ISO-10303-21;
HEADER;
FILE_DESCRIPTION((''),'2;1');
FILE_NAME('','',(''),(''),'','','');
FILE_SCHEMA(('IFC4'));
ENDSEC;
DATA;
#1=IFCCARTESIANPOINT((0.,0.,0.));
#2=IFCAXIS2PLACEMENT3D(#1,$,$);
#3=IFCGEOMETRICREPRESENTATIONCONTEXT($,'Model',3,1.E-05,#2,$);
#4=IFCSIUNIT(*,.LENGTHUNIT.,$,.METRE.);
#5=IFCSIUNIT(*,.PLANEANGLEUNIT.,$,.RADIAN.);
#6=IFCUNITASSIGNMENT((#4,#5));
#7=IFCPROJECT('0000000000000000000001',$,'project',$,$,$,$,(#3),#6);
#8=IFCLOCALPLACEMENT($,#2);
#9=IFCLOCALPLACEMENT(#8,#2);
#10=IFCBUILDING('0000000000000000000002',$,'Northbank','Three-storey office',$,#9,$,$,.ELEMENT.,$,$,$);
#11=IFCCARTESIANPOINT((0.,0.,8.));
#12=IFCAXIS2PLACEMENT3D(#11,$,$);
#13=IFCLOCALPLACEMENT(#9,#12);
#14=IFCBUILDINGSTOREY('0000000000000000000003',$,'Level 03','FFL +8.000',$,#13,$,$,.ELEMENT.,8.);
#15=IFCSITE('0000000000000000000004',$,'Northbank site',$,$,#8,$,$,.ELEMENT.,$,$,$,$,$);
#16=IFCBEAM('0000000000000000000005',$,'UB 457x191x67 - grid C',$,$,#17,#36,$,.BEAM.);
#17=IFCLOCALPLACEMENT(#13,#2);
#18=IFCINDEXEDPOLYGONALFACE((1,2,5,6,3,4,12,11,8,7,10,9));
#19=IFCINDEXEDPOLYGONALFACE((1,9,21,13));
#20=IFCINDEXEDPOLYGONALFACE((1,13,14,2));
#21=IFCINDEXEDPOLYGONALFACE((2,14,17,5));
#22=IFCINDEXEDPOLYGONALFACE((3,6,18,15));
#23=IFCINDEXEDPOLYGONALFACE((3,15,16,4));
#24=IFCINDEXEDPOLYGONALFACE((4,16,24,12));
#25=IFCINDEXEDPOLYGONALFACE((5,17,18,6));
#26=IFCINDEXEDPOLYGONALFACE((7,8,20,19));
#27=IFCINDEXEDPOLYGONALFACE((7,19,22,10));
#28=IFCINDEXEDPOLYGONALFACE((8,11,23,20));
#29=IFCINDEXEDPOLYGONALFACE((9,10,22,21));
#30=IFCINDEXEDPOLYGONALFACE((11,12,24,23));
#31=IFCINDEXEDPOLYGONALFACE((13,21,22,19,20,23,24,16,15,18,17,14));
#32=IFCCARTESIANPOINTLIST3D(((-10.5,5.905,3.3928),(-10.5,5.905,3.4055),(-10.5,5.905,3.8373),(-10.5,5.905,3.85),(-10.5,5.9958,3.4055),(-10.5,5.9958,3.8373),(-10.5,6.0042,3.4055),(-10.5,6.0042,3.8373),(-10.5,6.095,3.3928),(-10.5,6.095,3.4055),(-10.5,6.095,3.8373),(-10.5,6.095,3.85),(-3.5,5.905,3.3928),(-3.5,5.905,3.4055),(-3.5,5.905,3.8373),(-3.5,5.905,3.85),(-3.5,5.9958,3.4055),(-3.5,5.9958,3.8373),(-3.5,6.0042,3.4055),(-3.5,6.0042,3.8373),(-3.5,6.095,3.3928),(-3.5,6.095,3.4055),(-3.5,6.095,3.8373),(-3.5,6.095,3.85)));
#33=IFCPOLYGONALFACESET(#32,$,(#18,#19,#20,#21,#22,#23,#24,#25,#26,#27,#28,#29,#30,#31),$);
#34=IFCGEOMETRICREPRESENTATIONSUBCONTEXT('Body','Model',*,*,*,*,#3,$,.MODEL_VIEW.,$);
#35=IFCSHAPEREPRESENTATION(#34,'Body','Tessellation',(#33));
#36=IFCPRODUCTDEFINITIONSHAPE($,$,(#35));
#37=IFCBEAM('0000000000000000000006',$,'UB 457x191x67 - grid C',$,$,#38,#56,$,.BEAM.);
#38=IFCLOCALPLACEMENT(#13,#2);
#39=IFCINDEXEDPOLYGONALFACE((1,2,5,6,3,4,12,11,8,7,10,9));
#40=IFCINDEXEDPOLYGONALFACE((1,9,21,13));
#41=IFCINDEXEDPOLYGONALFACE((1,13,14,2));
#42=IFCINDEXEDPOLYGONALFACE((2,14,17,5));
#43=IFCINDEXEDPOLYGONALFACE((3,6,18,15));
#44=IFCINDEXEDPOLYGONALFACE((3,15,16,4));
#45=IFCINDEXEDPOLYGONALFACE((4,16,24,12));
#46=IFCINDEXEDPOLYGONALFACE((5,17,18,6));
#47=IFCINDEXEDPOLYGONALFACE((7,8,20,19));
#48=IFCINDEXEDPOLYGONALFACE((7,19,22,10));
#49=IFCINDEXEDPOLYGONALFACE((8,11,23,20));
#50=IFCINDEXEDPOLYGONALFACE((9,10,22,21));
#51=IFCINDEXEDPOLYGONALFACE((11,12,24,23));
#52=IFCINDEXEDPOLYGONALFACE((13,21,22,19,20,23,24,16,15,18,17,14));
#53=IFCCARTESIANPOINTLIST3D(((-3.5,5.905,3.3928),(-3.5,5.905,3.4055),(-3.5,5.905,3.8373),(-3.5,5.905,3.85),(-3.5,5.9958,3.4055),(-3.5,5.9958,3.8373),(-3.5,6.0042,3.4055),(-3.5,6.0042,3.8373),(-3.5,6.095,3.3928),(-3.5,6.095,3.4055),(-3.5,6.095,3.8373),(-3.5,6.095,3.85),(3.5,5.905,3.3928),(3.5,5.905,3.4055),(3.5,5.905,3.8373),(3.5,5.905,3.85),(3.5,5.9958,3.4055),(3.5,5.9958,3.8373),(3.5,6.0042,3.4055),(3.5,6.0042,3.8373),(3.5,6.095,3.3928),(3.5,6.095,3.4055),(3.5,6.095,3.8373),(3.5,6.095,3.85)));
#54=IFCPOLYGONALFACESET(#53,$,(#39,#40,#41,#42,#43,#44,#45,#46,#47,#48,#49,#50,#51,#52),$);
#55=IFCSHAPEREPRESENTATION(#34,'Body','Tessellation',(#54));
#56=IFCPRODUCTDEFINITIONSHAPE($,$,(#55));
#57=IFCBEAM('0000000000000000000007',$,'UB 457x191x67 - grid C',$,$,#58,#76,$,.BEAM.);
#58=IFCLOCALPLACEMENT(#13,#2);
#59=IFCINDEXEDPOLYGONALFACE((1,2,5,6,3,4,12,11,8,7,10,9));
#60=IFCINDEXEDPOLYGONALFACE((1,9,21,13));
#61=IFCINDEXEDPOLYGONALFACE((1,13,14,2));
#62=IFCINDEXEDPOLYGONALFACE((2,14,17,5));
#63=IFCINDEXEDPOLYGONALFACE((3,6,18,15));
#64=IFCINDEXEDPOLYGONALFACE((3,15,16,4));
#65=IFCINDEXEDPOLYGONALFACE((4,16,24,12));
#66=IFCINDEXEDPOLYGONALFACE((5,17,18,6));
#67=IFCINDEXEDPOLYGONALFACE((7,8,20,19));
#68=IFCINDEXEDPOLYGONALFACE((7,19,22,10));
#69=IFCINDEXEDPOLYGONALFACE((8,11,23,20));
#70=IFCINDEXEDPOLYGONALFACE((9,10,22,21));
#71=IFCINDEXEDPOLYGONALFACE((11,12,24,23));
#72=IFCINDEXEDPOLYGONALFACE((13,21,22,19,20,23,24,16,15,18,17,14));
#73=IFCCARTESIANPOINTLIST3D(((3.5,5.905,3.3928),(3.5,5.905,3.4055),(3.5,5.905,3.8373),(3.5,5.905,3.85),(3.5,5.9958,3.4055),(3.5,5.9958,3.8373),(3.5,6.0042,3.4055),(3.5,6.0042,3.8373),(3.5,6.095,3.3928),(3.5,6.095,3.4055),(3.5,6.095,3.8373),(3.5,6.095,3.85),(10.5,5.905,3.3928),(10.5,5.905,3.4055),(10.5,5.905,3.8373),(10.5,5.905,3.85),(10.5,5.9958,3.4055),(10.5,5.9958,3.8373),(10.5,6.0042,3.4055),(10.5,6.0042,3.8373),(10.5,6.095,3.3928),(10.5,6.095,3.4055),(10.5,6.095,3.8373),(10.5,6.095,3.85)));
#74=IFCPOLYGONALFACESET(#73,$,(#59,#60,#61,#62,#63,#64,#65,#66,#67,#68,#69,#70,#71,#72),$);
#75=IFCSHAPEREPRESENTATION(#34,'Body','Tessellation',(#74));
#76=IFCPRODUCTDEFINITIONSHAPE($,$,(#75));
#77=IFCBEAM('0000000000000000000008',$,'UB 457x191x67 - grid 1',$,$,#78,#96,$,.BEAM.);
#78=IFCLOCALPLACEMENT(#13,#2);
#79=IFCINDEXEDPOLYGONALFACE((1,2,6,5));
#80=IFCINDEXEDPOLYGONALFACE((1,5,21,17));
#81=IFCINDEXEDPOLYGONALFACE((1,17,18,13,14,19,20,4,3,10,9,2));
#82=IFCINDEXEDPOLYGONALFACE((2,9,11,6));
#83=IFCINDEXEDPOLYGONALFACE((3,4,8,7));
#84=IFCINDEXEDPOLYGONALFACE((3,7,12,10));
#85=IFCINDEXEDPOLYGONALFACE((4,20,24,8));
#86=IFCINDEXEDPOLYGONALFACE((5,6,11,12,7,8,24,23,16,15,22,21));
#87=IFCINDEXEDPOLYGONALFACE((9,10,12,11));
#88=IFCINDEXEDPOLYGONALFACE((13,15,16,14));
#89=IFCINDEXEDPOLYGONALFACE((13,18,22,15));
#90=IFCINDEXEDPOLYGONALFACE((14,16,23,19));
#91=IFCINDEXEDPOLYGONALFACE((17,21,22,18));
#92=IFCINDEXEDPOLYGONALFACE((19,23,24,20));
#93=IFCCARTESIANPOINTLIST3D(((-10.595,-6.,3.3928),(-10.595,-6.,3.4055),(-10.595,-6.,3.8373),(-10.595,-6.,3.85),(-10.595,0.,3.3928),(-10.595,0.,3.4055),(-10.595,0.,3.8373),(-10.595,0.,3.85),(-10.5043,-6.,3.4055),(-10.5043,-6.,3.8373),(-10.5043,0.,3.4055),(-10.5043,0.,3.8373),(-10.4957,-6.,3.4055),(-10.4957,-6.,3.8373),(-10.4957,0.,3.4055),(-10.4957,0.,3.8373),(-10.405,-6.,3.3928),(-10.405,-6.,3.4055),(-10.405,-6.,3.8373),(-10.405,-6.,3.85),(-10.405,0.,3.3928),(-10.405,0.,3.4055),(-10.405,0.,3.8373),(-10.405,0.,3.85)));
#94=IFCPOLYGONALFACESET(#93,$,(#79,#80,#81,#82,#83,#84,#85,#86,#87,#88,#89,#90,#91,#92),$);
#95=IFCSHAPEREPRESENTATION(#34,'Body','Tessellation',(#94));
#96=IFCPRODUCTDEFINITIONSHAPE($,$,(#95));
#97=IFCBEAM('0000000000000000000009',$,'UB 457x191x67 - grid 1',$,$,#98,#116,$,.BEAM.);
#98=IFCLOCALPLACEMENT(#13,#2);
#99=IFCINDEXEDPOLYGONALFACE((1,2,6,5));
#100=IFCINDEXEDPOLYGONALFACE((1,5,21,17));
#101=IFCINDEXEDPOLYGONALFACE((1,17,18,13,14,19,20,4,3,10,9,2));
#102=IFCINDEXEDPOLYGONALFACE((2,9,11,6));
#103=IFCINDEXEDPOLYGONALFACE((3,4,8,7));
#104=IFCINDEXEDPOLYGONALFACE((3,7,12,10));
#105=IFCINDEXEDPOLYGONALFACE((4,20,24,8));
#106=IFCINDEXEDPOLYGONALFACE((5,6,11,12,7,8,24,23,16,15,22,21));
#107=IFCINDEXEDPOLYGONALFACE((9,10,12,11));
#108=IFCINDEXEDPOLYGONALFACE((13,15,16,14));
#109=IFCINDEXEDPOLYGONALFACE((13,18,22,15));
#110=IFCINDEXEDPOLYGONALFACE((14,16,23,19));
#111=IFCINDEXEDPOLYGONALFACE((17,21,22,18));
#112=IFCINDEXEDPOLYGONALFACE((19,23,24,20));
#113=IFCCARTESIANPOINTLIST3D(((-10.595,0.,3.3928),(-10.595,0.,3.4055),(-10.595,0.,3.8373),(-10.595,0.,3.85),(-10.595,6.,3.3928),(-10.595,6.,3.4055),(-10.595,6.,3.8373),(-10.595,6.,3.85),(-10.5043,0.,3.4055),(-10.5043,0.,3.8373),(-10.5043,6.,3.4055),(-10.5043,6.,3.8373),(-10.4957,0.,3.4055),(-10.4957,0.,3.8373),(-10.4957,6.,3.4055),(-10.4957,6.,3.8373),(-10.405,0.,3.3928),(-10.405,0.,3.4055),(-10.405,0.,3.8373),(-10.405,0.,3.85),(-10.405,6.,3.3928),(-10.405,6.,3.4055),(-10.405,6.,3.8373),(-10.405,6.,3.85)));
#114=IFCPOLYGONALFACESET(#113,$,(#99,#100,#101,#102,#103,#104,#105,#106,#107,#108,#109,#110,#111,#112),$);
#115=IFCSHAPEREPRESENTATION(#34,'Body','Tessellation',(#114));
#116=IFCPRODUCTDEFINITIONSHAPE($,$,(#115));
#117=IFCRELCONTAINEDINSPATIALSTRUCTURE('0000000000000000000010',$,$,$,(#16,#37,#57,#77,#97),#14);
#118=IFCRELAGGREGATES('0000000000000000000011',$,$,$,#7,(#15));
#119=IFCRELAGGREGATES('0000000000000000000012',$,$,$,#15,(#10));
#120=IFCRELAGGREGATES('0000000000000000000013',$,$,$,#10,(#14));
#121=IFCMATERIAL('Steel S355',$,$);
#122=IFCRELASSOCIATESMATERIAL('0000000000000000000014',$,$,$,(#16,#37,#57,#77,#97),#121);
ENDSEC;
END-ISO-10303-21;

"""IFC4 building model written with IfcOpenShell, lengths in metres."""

from ifc_helpers import new_model, si_unit, frame, origin, place, context, subcontext, project, spatial, i_section, extrude, material, element, save


model = new_model("IFC4")

# Units and contexts
model_context = context("Model", 3, precision=1e-05, world=origin())
body_context = subcontext(model_context, "Body", "Model", "MODEL_VIEW")
ifc_project = project(units=[si_unit("LENGTHUNIT", "METRE"), si_unit("PLANEANGLEUNIT", "RADIAN")], contexts=[model_context])

# Site, building, storey
site_placement = place(None, origin())
site = spatial("IfcSite", under=ifc_project, at=site_placement, Name="Northbank site", CompositionType="ELEMENT")
building_placement = place(site_placement, origin())
building = spatial("IfcBuilding", under=site, at=building_placement, Name="Northbank", Description="Three-storey office", CompositionType="ELEMENT")
storey_placement = place(building_placement, frame((0.0, 0.0, 8.0)))
storey = spatial("IfcBuildingStorey", under=building, at=storey_placement, Name="Level 03", Description="FFL +8.000", CompositionType="ELEMENT", Elevation=8.0)

# Shared definitions
ifc_material = material(Name="Steel S355")

# Beams
beam_1_placement = place(storey_placement, frame((0.0, 0.0, -8.0)))
element("IfcBeam", 1, at=beam_1_placement, inside=storey, material=ifc_material, Name="UB 457x191x67 - grid C", PredefinedType="BEAM", context=body_context, shape_type="SweptSolid", body=[
    extrude(i_section(OverallWidth=0.1899, OverallDepth=0.4572, WebThickness=0.0085, FlangeThickness=0.0127), frame((-10.5, 6.0, 11.6214), z_axis=(1.0, 0.0, 0.0), x_axis=(0.0, 1.0, 0.0)), (0.0, 0.0, 1.0), 7.0),
])
beam_2_placement = place(storey_placement, frame((0.0, 0.0, -8.0)))
element("IfcBeam", 2, at=beam_2_placement, inside=storey, material=ifc_material, Name="UB 457x191x67 - grid C", PredefinedType="BEAM", context=body_context, shape_type="SweptSolid", body=[
    extrude(i_section(OverallWidth=0.1899, OverallDepth=0.4572, WebThickness=0.0085, FlangeThickness=0.0127), frame((-3.5, 6.0, 11.6214), z_axis=(1.0, 0.0, 0.0), x_axis=(0.0, 1.0, 0.0)), (0.0, 0.0, 1.0), 7.0),
])
beam_3_placement = place(storey_placement, frame((0.0, 0.0, -8.0)))
element("IfcBeam", 3, at=beam_3_placement, inside=storey, material=ifc_material, Name="UB 457x191x67 - grid C", PredefinedType="BEAM", context=body_context, shape_type="SweptSolid", body=[
    extrude(i_section(OverallWidth=0.1899, OverallDepth=0.4572, WebThickness=0.0085, FlangeThickness=0.0127), frame((3.5, 6.0, 11.6214), z_axis=(1.0, 0.0, 0.0), x_axis=(0.0, 1.0, 0.0)), (0.0, 0.0, 1.0), 7.0),
])
beam_4_placement = place(storey_placement, frame((0.0, 0.0, -8.0)))
element("IfcBeam", 4, at=beam_4_placement, inside=storey, material=ifc_material, Name="UB 457x191x67 - grid 1", PredefinedType="BEAM", context=body_context, shape_type="SweptSolid", body=[
    extrude(i_section(OverallWidth=0.1899, OverallDepth=0.4572, WebThickness=0.0085, FlangeThickness=0.0127), frame((-10.5, -6.0, 11.6214), z_axis=(0.0, 1.0, 0.0), x_axis=(-1.0, 0.0, 0.0)), (0.0, 0.0, 1.0), 6.0),
])
beam_5_placement = place(storey_placement, frame((0.0, 0.0, -8.0)))
element("IfcBeam", 5, at=beam_5_placement, inside=storey, material=ifc_material, Name="UB 457x191x67 - grid 1", PredefinedType="BEAM", context=body_context, shape_type="SweptSolid", body=[
    extrude(i_section(OverallWidth=0.1899, OverallDepth=0.4572, WebThickness=0.0085, FlangeThickness=0.0127), frame((-10.5, 0.0, 11.6214), z_axis=(0.0, 1.0, 0.0), x_axis=(-1.0, 0.0, 0.0)), (0.0, 0.0, 1.0), 6.0),
])

save(model, "model.ifc")
